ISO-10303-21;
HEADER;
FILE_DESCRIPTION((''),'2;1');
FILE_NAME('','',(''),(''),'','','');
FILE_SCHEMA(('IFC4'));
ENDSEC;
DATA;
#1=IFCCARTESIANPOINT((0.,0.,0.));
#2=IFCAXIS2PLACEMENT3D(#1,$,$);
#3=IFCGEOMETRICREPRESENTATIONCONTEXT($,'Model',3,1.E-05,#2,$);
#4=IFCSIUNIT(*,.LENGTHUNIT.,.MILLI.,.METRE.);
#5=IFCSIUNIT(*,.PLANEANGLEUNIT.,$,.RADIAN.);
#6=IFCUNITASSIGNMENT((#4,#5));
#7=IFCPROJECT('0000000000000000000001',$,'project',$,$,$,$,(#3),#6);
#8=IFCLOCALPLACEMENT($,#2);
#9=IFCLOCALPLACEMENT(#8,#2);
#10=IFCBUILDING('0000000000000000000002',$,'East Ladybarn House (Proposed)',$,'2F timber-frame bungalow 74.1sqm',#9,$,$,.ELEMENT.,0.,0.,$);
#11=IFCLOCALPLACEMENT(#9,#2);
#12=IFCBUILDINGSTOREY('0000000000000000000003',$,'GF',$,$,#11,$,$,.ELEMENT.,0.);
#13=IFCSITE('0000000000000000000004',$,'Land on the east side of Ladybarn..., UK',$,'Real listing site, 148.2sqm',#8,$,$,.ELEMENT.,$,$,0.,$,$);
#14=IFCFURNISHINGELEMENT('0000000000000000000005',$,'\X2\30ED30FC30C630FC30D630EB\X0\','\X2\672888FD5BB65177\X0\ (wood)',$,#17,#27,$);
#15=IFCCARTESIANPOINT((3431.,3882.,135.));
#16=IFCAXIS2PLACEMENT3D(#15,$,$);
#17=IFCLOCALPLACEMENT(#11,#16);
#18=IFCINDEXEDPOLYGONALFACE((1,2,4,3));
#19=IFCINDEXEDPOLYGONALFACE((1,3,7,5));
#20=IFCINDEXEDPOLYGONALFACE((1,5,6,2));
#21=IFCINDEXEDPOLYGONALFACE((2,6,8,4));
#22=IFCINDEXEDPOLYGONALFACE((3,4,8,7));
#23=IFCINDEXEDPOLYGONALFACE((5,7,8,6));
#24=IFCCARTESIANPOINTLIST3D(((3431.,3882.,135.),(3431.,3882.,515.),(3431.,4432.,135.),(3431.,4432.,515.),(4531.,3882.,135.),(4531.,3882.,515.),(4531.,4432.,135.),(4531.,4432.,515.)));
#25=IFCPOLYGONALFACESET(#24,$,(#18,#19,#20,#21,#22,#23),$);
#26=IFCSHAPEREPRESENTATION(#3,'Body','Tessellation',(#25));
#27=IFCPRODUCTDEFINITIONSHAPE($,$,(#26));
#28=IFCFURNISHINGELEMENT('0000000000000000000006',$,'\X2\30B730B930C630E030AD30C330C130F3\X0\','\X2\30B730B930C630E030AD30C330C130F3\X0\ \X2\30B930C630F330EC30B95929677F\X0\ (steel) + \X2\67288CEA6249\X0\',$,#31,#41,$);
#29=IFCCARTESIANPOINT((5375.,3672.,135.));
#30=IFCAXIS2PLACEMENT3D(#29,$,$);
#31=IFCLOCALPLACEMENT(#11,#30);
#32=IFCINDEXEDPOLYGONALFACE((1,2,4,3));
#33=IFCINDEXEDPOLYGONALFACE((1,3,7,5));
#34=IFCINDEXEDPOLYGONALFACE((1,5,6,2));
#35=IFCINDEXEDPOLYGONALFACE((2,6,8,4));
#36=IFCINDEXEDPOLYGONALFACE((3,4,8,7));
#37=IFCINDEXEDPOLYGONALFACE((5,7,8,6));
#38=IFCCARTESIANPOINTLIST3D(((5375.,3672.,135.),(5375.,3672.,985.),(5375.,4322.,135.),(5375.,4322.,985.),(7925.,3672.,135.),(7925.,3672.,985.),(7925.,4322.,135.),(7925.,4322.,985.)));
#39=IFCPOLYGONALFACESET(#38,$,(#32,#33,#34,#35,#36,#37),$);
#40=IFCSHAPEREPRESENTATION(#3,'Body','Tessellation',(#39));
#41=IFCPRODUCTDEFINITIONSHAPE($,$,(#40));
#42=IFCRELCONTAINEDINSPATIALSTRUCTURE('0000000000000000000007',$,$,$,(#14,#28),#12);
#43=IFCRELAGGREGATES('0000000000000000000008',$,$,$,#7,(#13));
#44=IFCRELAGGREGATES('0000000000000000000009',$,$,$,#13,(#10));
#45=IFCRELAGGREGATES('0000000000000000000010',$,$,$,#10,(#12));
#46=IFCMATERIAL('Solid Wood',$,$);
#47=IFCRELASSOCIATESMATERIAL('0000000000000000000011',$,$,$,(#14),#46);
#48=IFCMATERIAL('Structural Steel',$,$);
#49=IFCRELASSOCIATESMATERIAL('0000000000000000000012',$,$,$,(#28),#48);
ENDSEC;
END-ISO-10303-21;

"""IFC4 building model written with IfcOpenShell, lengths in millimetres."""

from ifc_helpers import new_model, si_unit, frame, frame_2d, origin, place, context, project, spatial, rectangle, extrude, material, element, save


model = new_model("IFC4")

# Units and contexts
model_context = context("Model", 3, precision=1e-05, world=origin())
ifc_project = project(units=[si_unit("LENGTHUNIT", "METRE", prefix="MILLI"), si_unit("PLANEANGLEUNIT", "RADIAN")], contexts=[model_context])

# Site, building, storey
site_placement = place(None, origin())
site = spatial("IfcSite", under=ifc_project, at=site_placement, Name="Land on the east side of Ladybarn..., UK", ObjectType="Real listing site, 148.2sqm", CompositionType="ELEMENT", RefElevation=0.0)
building_placement = place(site_placement, origin())
building = spatial("IfcBuilding", under=site, at=building_placement, Name="East Ladybarn House (Proposed)", ObjectType="2F timber-frame bungalow 74.1sqm", CompositionType="ELEMENT", ElevationOfRefHeight=0.0, ElevationOfTerrain=0.0)
storey_placement = place(building_placement, origin())
storey = spatial("IfcBuildingStorey", under=building, at=storey_placement, Name="GF", CompositionType="ELEMENT", Elevation=0.0)

# Shared definitions
ifc_material_1 = material(Name="Solid Wood")

# Furnishing elements
furnishing_1_placement = place(storey_placement, frame((3431.0, 3882.0, 135.0)))
element("IfcFurnishingElement", 1, at=furnishing_1_placement, inside=storey, material=ifc_material_1, Name="ローテーブル", Description="木製家具 (wood)", context=model_context, shape_type="SweptSolid", body=[
    extrude(rectangle(XDim=1100.0, YDim=550.0, at=frame_2d((550.0, 275.0))), frame((3431.0, 3882.0, 135.0)), (0.0, 0.0, 1.0), 380.0),
])
ifc_material_2 = material(Name="Structural Steel")
furnishing_2_placement = place(storey_placement, frame((5375.0, 3672.0, 135.0)))
element("IfcFurnishingElement", 2, at=furnishing_2_placement, inside=storey, material=ifc_material_2, Name="システムキッチン", Description="システムキッチン ステンレス天板 (steel) + 木質扉", context=model_context, shape_type="SweptSolid", body=[
    extrude(rectangle(XDim=2550.0, YDim=650.0, at=frame_2d((1275.0, 325.0))), frame((5375.0, 3672.0, 135.0)), (0.0, 0.0, 1.0), 850.0),
])

save(model, "model.ifc")
